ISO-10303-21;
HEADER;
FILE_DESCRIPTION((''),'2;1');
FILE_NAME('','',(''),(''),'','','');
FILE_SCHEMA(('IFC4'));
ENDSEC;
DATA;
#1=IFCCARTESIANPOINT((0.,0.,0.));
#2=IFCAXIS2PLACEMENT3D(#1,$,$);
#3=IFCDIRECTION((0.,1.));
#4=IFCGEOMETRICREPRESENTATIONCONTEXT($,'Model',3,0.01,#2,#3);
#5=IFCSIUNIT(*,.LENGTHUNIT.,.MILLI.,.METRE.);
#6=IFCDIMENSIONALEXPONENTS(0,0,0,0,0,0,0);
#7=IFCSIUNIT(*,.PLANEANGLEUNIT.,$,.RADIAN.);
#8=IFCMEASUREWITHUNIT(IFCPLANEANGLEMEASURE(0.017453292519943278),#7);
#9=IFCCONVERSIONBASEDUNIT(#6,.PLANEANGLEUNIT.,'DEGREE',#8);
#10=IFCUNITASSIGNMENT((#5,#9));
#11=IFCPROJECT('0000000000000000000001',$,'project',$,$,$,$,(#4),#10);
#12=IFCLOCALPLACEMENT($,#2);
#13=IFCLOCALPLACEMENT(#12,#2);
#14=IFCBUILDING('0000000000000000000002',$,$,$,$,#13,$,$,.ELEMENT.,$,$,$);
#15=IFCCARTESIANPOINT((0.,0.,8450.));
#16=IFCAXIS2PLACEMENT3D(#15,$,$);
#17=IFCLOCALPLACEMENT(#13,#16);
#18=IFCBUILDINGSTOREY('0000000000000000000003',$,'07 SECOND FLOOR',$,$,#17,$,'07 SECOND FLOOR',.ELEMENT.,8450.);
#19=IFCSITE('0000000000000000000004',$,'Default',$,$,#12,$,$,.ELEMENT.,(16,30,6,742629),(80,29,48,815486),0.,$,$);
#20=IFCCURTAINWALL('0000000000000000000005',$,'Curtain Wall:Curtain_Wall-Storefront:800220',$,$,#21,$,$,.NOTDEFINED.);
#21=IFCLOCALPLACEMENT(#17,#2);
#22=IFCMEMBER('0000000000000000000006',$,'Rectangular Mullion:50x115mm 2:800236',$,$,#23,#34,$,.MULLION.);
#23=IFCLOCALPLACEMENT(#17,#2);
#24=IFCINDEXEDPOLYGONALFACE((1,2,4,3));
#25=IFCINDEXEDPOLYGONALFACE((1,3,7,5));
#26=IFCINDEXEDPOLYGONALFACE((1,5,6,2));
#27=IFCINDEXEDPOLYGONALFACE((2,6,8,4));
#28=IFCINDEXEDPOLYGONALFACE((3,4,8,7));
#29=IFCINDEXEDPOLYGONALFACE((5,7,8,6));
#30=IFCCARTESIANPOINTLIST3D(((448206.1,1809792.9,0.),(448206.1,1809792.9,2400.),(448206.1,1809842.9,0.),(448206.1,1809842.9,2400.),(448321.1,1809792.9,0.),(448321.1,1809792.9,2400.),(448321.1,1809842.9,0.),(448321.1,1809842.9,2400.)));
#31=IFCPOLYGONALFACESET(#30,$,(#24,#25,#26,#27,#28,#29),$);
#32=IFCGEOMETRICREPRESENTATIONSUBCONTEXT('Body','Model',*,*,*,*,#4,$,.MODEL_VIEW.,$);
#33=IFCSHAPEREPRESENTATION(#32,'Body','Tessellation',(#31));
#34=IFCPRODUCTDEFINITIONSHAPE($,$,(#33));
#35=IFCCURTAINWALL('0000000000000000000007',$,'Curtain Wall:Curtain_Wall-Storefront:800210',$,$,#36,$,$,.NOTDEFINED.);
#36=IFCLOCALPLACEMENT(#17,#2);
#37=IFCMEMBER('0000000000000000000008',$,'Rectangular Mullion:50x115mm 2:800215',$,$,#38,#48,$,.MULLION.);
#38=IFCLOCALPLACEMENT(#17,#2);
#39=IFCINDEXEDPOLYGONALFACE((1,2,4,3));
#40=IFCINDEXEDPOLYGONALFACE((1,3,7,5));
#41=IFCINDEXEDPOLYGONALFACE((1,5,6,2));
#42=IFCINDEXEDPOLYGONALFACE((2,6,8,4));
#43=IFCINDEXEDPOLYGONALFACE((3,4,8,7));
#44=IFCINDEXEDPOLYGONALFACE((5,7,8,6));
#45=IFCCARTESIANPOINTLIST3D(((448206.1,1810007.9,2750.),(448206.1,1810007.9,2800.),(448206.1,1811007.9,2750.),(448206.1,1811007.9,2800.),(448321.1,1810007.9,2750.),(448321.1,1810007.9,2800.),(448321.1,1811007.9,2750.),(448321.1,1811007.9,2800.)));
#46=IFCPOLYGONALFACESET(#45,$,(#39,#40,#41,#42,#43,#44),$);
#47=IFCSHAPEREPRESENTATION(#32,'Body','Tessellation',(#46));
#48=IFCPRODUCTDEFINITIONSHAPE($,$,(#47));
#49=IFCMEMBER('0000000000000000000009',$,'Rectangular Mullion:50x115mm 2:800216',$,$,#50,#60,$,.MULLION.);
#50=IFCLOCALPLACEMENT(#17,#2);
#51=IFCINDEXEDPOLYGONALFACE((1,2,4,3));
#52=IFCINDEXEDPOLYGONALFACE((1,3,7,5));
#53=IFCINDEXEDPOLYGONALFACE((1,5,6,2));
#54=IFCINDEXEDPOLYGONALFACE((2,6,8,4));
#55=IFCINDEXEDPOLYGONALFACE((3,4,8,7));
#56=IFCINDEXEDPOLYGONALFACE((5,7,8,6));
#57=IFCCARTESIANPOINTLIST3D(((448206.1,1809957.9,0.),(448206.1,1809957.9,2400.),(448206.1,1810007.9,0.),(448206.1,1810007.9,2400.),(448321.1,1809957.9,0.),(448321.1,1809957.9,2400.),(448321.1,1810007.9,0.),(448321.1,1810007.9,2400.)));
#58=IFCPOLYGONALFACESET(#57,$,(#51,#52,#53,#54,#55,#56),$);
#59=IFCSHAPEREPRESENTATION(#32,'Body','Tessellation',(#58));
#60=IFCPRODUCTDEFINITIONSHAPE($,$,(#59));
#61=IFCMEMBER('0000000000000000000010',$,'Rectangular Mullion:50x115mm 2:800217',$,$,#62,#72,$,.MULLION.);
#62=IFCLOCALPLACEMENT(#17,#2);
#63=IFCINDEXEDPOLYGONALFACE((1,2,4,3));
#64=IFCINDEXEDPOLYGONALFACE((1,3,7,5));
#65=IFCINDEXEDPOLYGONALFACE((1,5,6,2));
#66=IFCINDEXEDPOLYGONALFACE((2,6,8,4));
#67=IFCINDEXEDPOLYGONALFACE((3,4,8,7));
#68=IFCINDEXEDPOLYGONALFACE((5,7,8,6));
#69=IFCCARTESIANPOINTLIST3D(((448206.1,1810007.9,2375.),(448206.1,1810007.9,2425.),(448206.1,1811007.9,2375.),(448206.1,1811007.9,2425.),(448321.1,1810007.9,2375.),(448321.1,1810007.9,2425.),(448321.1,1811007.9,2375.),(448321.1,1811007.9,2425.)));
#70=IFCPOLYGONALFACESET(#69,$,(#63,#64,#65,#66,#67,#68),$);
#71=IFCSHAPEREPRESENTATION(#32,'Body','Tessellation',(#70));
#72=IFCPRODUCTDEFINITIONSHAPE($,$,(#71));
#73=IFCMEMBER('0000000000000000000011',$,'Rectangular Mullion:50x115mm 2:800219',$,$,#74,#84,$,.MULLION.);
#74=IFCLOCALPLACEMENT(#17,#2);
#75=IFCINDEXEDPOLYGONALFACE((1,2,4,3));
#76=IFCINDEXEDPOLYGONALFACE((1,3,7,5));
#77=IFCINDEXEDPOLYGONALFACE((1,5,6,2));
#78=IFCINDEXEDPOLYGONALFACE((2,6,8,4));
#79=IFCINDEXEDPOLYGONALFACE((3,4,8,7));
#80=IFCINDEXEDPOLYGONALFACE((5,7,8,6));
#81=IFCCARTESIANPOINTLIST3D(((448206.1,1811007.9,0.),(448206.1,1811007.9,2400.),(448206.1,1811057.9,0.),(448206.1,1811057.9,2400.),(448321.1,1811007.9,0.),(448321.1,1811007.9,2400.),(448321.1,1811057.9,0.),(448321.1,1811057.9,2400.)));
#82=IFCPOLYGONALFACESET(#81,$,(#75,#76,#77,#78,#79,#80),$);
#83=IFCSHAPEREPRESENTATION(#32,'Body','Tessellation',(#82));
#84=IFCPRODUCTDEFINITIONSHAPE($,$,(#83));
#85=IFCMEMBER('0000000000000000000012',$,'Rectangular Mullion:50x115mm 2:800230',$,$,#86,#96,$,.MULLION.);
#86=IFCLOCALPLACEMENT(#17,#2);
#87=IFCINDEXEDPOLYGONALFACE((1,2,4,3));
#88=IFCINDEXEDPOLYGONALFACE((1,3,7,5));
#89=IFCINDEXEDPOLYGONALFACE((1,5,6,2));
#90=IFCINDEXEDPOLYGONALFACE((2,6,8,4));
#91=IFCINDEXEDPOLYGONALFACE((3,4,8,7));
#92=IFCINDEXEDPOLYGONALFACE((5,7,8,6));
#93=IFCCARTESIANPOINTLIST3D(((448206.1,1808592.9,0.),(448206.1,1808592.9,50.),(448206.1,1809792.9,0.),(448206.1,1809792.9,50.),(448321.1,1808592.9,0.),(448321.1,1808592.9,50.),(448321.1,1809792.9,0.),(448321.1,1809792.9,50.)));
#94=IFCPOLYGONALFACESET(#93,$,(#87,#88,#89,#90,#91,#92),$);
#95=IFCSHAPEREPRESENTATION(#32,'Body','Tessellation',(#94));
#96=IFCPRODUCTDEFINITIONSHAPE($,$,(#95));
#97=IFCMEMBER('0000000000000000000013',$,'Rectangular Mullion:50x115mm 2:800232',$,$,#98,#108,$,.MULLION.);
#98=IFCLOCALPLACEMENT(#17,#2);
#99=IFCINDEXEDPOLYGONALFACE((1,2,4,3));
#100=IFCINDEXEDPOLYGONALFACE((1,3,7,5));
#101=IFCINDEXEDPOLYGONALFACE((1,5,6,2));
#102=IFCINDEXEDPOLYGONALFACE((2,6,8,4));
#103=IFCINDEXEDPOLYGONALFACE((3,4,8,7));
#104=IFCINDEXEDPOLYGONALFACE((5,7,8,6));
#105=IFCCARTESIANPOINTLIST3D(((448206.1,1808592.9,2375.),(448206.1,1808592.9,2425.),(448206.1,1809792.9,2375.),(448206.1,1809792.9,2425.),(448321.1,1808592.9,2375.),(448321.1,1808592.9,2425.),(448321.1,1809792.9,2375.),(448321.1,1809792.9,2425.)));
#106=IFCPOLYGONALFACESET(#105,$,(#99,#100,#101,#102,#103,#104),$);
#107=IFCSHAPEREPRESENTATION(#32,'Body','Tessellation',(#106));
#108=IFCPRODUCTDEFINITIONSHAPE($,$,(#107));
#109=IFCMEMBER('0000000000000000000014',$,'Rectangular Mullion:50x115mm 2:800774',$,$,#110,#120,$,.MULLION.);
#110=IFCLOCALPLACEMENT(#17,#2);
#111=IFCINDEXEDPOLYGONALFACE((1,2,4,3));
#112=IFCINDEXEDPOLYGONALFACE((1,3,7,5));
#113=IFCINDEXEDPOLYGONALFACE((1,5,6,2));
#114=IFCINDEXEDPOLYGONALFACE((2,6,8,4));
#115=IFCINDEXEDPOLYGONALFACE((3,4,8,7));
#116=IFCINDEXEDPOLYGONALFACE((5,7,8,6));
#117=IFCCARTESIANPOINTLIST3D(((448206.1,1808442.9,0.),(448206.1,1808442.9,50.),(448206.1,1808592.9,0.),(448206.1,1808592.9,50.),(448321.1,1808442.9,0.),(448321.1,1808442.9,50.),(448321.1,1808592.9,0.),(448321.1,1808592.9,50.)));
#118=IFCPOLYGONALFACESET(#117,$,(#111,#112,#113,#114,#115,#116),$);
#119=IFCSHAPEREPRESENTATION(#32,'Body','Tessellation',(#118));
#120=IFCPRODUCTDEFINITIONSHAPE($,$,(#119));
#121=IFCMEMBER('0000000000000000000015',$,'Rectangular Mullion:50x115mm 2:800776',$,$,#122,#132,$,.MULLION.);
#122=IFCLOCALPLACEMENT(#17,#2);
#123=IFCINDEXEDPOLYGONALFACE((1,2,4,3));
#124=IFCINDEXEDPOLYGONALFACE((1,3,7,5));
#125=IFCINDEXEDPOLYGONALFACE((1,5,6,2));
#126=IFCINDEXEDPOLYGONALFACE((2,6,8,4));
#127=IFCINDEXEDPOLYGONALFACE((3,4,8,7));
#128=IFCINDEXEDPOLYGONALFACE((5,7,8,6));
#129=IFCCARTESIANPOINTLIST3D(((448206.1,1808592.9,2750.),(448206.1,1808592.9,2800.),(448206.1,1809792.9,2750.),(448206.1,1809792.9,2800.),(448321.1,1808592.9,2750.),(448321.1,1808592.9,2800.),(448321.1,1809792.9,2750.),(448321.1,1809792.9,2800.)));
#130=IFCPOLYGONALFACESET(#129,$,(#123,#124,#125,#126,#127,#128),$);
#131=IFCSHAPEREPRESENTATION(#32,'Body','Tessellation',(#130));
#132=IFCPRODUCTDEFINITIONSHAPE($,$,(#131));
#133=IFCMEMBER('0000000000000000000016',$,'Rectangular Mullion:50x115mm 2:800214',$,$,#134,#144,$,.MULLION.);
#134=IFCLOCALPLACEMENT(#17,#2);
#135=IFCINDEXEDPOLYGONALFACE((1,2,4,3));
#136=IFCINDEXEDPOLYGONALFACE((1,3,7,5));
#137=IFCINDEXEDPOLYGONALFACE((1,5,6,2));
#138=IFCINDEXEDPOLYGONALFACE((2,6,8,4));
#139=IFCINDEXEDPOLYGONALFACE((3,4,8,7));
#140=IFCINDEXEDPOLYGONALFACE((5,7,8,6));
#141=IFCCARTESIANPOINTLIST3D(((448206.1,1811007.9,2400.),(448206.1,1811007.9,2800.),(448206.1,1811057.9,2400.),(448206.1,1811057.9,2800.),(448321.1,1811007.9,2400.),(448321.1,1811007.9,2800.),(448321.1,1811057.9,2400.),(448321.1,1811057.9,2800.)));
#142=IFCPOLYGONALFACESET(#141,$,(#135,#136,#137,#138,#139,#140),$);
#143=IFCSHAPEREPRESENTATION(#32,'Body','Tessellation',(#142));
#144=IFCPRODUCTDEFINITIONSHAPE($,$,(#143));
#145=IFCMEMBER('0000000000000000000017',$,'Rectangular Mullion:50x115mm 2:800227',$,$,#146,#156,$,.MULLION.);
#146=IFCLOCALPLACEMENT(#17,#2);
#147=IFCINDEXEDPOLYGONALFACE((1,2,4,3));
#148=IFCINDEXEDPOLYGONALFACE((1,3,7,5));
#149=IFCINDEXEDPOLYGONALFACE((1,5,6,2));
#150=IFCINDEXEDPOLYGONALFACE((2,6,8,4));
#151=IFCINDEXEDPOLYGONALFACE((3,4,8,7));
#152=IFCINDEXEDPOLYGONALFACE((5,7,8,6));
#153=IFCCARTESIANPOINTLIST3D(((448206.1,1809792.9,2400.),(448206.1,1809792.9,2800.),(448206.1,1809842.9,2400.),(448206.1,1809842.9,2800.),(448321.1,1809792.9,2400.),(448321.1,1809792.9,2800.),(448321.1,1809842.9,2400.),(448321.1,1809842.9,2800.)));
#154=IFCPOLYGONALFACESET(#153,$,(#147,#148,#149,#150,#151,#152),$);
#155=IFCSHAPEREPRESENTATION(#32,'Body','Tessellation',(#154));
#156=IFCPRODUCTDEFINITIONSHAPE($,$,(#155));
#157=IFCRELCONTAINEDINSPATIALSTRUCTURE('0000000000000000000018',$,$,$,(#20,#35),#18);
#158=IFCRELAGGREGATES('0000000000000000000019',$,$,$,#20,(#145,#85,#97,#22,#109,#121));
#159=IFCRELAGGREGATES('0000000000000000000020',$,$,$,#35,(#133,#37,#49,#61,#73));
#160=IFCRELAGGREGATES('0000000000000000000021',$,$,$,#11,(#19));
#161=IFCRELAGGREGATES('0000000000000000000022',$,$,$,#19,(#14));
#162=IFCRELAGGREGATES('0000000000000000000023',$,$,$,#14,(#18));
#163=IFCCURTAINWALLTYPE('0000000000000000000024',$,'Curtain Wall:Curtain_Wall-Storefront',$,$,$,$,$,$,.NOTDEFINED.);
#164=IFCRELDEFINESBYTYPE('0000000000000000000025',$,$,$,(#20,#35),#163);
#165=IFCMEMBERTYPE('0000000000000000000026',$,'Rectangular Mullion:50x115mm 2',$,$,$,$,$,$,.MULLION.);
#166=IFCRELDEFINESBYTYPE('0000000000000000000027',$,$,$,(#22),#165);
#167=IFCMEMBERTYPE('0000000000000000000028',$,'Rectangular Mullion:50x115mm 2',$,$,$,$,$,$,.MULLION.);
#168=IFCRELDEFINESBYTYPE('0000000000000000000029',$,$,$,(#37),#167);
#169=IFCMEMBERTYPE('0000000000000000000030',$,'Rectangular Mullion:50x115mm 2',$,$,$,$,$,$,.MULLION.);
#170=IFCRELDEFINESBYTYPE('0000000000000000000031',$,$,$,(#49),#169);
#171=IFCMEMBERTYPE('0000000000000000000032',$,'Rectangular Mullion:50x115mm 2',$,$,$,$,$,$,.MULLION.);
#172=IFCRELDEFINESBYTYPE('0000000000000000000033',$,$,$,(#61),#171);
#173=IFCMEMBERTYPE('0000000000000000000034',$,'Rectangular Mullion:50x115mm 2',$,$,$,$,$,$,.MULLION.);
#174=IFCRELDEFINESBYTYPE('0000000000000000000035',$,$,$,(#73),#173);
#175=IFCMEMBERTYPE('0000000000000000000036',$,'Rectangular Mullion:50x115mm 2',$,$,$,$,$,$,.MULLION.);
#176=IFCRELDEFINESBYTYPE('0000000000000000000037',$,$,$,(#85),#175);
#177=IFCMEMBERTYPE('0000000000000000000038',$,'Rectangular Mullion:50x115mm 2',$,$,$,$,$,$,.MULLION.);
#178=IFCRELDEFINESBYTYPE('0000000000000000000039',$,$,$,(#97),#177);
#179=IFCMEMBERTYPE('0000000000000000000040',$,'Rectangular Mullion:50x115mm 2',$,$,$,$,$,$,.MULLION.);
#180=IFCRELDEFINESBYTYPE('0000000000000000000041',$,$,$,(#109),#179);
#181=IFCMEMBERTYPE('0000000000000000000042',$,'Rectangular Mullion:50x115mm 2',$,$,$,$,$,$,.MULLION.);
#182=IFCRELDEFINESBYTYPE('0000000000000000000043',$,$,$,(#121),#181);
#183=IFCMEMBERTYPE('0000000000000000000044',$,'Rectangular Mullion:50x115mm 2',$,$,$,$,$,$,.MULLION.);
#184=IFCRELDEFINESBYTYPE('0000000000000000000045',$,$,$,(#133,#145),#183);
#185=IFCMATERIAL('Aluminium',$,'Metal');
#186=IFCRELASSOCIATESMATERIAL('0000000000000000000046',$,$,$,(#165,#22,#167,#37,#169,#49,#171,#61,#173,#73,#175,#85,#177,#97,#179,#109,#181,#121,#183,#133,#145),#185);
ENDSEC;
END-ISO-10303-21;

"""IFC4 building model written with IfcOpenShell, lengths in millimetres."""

from ifc_helpers import new_model, entity, si_unit, converted_unit, direction, frame, origin, place, context, subcontext, project, spatial, indexed_curve, outline, extrude, source, transform, mapped, material, type_object, type_shapes, element, aggregate, save


model = new_model("IFC4")

# Units and contexts
model_context = context("Model", 3, precision=0.01, world=origin(), true_north=direction((0.0, 1.0)))
body_context = subcontext(model_context, "Body", "Model", "MODEL_VIEW")
ifc_project = project(units=[si_unit("LENGTHUNIT", "METRE", prefix="MILLI"), converted_unit("PLANEANGLEUNIT", "DEGREE", entity("IfcPlaneAngleMeasure", 0.017453292519943278), si_unit("PLANEANGLEUNIT", "RADIAN"), dimensions=[0, 0, 0, 0, 0, 0, 0])], contexts=[model_context])

# Site, building, storey
site_placement = place(None, origin())
site = spatial("IfcSite", under=ifc_project, at=site_placement, Name="Default", CompositionType="ELEMENT", RefLatitude=(16, 30, 6, 742629), RefLongitude=(80, 29, 48, 815486), RefElevation=0.0)
building_placement = place(site_placement, origin())
building = spatial("IfcBuilding", under=site, at=building_placement, CompositionType="ELEMENT")
storey_placement = place(building_placement, frame((0.0, 0.0, 8450.0)))
storey = spatial("IfcBuildingStorey", under=building, at=storey_placement, Name="07 SECOND FLOOR", LongName="07 SECOND FLOOR", CompositionType="ELEMENT", Elevation=8450.0)

# Curtain wall, member
curtain_wall_type = type_object("IfcCurtainWallType", Name="Curtain Wall:Curtain_Wall-Storefront", PredefinedType="NOTDEFINED")
curtain_wall_1_placement = place(storey_placement, frame((0.0, 0.0, -8450.0)))
curtain_wall_1 = element("IfcCurtainWall", 1, at=curtain_wall_1_placement, inside=storey, type_object=curtain_wall_type, Name="Curtain Wall:Curtain_Wall-Storefront:800220", PredefinedType="NOTDEFINED")
ifc_material_1 = material(Name="Aluminium", Category="Metal")
member_type_1 = type_object("IfcMemberType", Name="Rectangular Mullion:50x115mm 2", PredefinedType="MULLION", material=ifc_material_1)
shared_shape_1 = source(origin(), body_context, "Body", "SweptSolid", [
    extrude(outline(indexed_curve([(-25.0, -57.5), (25.0, -57.5), (25.0, 57.5), (-25.0, 57.5), (-25.0, -57.5)], self_intersect=False)), frame((-25.0, 0.0, -2400.0), z_axis=(0.0, 0.0, 1.0), x_axis=(-1.0, 0.0, 0.0)), (0.0, 0.0, 1.0), 2400.0),
])
type_shapes(member_type_1, [shared_shape_1])
member_1_placement = place(curtain_wall_1_placement, frame((448263.6, 1809842.9, 10850.0), z_axis=(0.0, 0.0, 1.0), x_axis=(0.0, 1.0, 0.0)))
member_1 = element("IfcMember", 2, at=member_1_placement, type_object=member_type_1, material=ifc_material_1, Name="Rectangular Mullion:50x115mm 2:800236", PredefinedType="MULLION", context=body_context, shape_type="MappedRepresentation", body=[
    mapped(shared_shape_1, transform((0.0, 0.0, 0.0), scale=1.0)),
])

# Curtain wall, members
curtain_wall_2_placement = place(storey_placement, frame((0.0, 0.0, -8450.0)))
curtain_wall_2 = element("IfcCurtainWall", 3, at=curtain_wall_2_placement, inside=storey, type_object=curtain_wall_type, Name="Curtain Wall:Curtain_Wall-Storefront:800210", PredefinedType="NOTDEFINED")
member_type_2 = type_object("IfcMemberType", Name="Rectangular Mullion:50x115mm 2", PredefinedType="MULLION", material=ifc_material_1)
shared_shape_2 = source(origin(), body_context, "Body", "SweptSolid", [
    extrude(outline(indexed_curve([(-25.0, -57.5), (25.0, -57.5), (25.0, 57.5), (-25.0, 57.5), (-25.0, -57.5)], self_intersect=False)), frame((-25.0, 0.0, -1000.0), z_axis=(0.0, 0.0, 1.0), x_axis=(-1.0, 0.0, 0.0)), (0.0, 0.0, 1.0), 1000.0),
])
type_shapes(member_type_2, [shared_shape_2])
member_2_placement = place(curtain_wall_2_placement, frame((448263.6, 1810007.9, 11250.0), z_axis=(0.0, -1.0, 0.0), x_axis=(0.0, 0.0, 1.0)))
member_2 = element("IfcMember", 4, at=member_2_placement, type_object=member_type_2, material=ifc_material_1, Name="Rectangular Mullion:50x115mm 2:800215", PredefinedType="MULLION", context=body_context, shape_type="MappedRepresentation", body=[
    mapped(shared_shape_2, transform((0.0, 0.0, 0.0), scale=1.0)),
])
member_type_3 = type_object("IfcMemberType", Name="Rectangular Mullion:50x115mm 2", PredefinedType="MULLION", material=ifc_material_1)
shared_shape_3 = source(origin(), body_context, "Body", "SweptSolid", [
    extrude(outline(indexed_curve([(-25.0, -57.5), (25.0, -57.5), (25.0, 57.5), (-25.0, 57.5), (-25.0, -57.5)], self_intersect=False)), frame((-25.0, 0.0, -2400.0), z_axis=(0.0, 0.0, 1.0), x_axis=(-1.0, 0.0, 0.0)), (0.0, 0.0, 1.0), 2400.0),
])
type_shapes(member_type_3, [shared_shape_3])
member_3_placement = place(curtain_wall_2_placement, frame((448263.6, 1809957.9, 8450.0), z_axis=(0.0, 0.0, -1.0), x_axis=(0.0, -1.0, 0.0)))
member_3 = element("IfcMember", 5, at=member_3_placement, type_object=member_type_3, material=ifc_material_1, Name="Rectangular Mullion:50x115mm 2:800216", PredefinedType="MULLION", context=body_context, shape_type="MappedRepresentation", body=[
    mapped(shared_shape_3, transform((0.0, 0.0, 0.0), scale=1.0)),
])
member_type_4 = type_object("IfcMemberType", Name="Rectangular Mullion:50x115mm 2", PredefinedType="MULLION", material=ifc_material_1)
shared_shape_4 = source(origin(), body_context, "Body", "SweptSolid", [
    extrude(outline(indexed_curve([(-25.0, -57.5), (25.0, -57.5), (25.0, 57.5), (-25.0, 57.5), (-25.0, -57.5)], self_intersect=False)), frame((0.0, 0.0, -1000.0), z_axis=(0.0, 0.0, 1.0), x_axis=(-1.0, 0.0, 0.0)), (0.0, 0.0, 1.0), 1000.0),
])
type_shapes(member_type_4, [shared_shape_4])
member_4_placement = place(curtain_wall_2_placement, frame((448263.6, 1810007.9, 10850.0), z_axis=(0.0, -1.0, 0.0), x_axis=(0.0, 0.0, 1.0)))
member_4 = element("IfcMember", 6, at=member_4_placement, type_object=member_type_4, material=ifc_material_1, Name="Rectangular Mullion:50x115mm 2:800217", PredefinedType="MULLION", context=body_context, shape_type="MappedRepresentation", body=[
    mapped(shared_shape_4, transform((0.0, 0.0, 0.0), scale=1.0)),
])
member_type_5 = type_object("IfcMemberType", Name="Rectangular Mullion:50x115mm 2", PredefinedType="MULLION", material=ifc_material_1)
shared_shape_5 = source(origin(), body_context, "Body", "SweptSolid", [
    extrude(outline(indexed_curve([(-25.0, -57.5), (25.0, -57.5), (25.0, 57.5), (-25.0, 57.5), (-25.0, -57.5)], self_intersect=False)), frame((-25.0, 0.0, -2400.0), z_axis=(0.0, 0.0, 1.0), x_axis=(-1.0, 0.0, 0.0)), (0.0, 0.0, 1.0), 2400.0),
])
type_shapes(member_type_5, [shared_shape_5])
member_5_placement = place(curtain_wall_2_placement, frame((448263.6, 1811057.9, 10850.0), z_axis=(0.0, 0.0, 1.0), x_axis=(0.0, 1.0, 0.0)))
member_5 = element("IfcMember", 7, at=member_5_placement, type_object=member_type_5, material=ifc_material_1, Name="Rectangular Mullion:50x115mm 2:800219", PredefinedType="MULLION", context=body_context, shape_type="MappedRepresentation", body=[
    mapped(shared_shape_5, transform((0.0, 0.0, 0.0), scale=1.0)),
])

# Members
member_type_6 = type_object("IfcMemberType", Name="Rectangular Mullion:50x115mm 2", PredefinedType="MULLION", material=ifc_material_1)
shared_shape_6 = source(origin(), body_context, "Body", "SweptSolid", [
    extrude(outline(indexed_curve([(-25.0, -57.5), (25.0, -57.5), (25.0, 57.5), (-25.0, 57.5), (-25.0, -57.5)], self_intersect=False)), frame((-25.0, 0.0, -1200.0), z_axis=(0.0, 0.0, 1.0), x_axis=(-1.0, 0.0, 0.0)), (0.0, 0.0, 1.0), 1200.0),
])
type_shapes(member_type_6, [shared_shape_6])
member_6_placement = place(curtain_wall_1_placement, frame((448263.6, 1809792.9, 8450.0), z_axis=(0.0, 1.0, 0.0), x_axis=(0.0, 0.0, -1.0)))
member_6 = element("IfcMember", 8, at=member_6_placement, type_object=member_type_6, material=ifc_material_1, Name="Rectangular Mullion:50x115mm 2:800230", PredefinedType="MULLION", context=body_context, shape_type="MappedRepresentation", body=[
    mapped(shared_shape_6, transform((0.0, 0.0, 0.0), scale=1.0)),
])
member_type_7 = type_object("IfcMemberType", Name="Rectangular Mullion:50x115mm 2", PredefinedType="MULLION", material=ifc_material_1)
shared_shape_7 = source(origin(), body_context, "Body", "SweptSolid", [
    extrude(outline(indexed_curve([(-25.0, -57.5), (25.0, -57.5), (25.0, 57.5), (-25.0, 57.5), (-25.0, -57.5)], self_intersect=False)), frame((0.0, 0.0, -1200.0), z_axis=(0.0, 0.0, 1.0), x_axis=(-1.0, 0.0, 0.0)), (0.0, 0.0, 1.0), 1200.0),
])
type_shapes(member_type_7, [shared_shape_7])
member_7_placement = place(curtain_wall_1_placement, frame((448263.6, 1808592.9, 10850.0), z_axis=(0.0, -1.0, 0.0), x_axis=(0.0, 0.0, 1.0)))
member_7 = element("IfcMember", 9, at=member_7_placement, type_object=member_type_7, material=ifc_material_1, Name="Rectangular Mullion:50x115mm 2:800232", PredefinedType="MULLION", context=body_context, shape_type="MappedRepresentation", body=[
    mapped(shared_shape_7, transform((0.0, 0.0, 0.0), scale=1.0)),
])
member_type_8 = type_object("IfcMemberType", Name="Rectangular Mullion:50x115mm 2", PredefinedType="MULLION", material=ifc_material_1)
shared_shape_8 = source(origin(), body_context, "Body", "SweptSolid", [
    extrude(outline(indexed_curve([(-25.0, -57.5), (25.0, -57.5), (25.0, 57.5), (-25.0, 57.5), (-25.0, -57.5)], self_intersect=False)), frame((-25.0, 0.0, -150.0), z_axis=(0.0, 0.0, 1.0), x_axis=(-1.0, 0.0, 0.0)), (0.0, 0.0, 1.0), 150.0),
])
type_shapes(member_type_8, [shared_shape_8])
member_8_placement = place(curtain_wall_1_placement, frame((448263.6, 1808592.9, 8450.0), z_axis=(0.0, 1.0, 0.0), x_axis=(0.0, 0.0, -1.0)))
member_8 = element("IfcMember", 10, at=member_8_placement, type_object=member_type_8, material=ifc_material_1, Name="Rectangular Mullion:50x115mm 2:800774", PredefinedType="MULLION", context=body_context, shape_type="MappedRepresentation", body=[
    mapped(shared_shape_8, transform((0.0, 0.0, 0.0), scale=1.0)),
])
member_type_9 = type_object("IfcMemberType", Name="Rectangular Mullion:50x115mm 2", PredefinedType="MULLION", material=ifc_material_1)
shared_shape_9 = source(origin(), body_context, "Body", "SweptSolid", [
    extrude(outline(indexed_curve([(-25.0, -57.5), (25.0, -57.5), (25.0, 57.5), (-25.0, 57.5), (-25.0, -57.5)], self_intersect=False)), frame((-25.0, 0.0, -1200.0), z_axis=(0.0, 0.0, 1.0), x_axis=(-1.0, 0.0, 0.0)), (0.0, 0.0, 1.0), 1200.0),
])
type_shapes(member_type_9, [shared_shape_9])
member_9_placement = place(curtain_wall_1_placement, frame((448263.6, 1808592.9, 11250.0), z_axis=(0.0, -1.0, 0.0), x_axis=(0.0, 0.0, 1.0)))
member_9 = element("IfcMember", 11, at=member_9_placement, type_object=member_type_9, material=ifc_material_1, Name="Rectangular Mullion:50x115mm 2:800776", PredefinedType="MULLION", context=body_context, shape_type="MappedRepresentation", body=[
    mapped(shared_shape_9, transform((0.0, 0.0, 0.0), scale=1.0)),
])
member_type_10 = type_object("IfcMemberType", Name="Rectangular Mullion:50x115mm 2", PredefinedType="MULLION", material=ifc_material_1)
shared_shape_10 = source(origin(), body_context, "Body", "SweptSolid", [
    extrude(outline(indexed_curve([(-25.0, -57.5), (25.0, -57.5), (25.0, 57.5), (-25.0, 57.5), (-25.0, -57.5)], self_intersect=False)), frame((-25.0, 0.0, -400.0), z_axis=(0.0, 0.0, 1.0), x_axis=(-1.0, 0.0, 0.0)), (0.0, 0.0, 1.0), 400.0),
])
type_shapes(member_type_10, [shared_shape_10])
member_10_placement = place(curtain_wall_2_placement, frame((448263.6, 1811057.9, 11250.0), z_axis=(0.0, 0.0, 1.0), x_axis=(0.0, 1.0, 0.0)))
member_10 = element("IfcMember", 12, at=member_10_placement, type_object=member_type_10, material=ifc_material_1, Name="Rectangular Mullion:50x115mm 2:800214", PredefinedType="MULLION", context=body_context, shape_type="MappedRepresentation", body=[
    mapped(shared_shape_10, transform((0.0, 0.0, 0.0), scale=1.0)),
])
member_11_placement = place(curtain_wall_1_placement, frame((448263.6, 1809842.9, 11250.0), z_axis=(0.0, 0.0, 1.0), x_axis=(0.0, 1.0, 0.0)))
member_11 = element("IfcMember", 13, at=member_11_placement, type_object=member_type_10, material=ifc_material_1, Name="Rectangular Mullion:50x115mm 2:800227", PredefinedType="MULLION", context=body_context, shape_type="MappedRepresentation", body=[
    mapped(shared_shape_10, transform((0.0, 0.0, 0.0), scale=1.0)),
])

aggregate(curtain_wall_1, [member_11, member_6, member_7, member_1, member_8, member_9])

aggregate(curtain_wall_2, [member_10, member_2, member_3, member_4, member_5])

save(model, "model.ifc")
